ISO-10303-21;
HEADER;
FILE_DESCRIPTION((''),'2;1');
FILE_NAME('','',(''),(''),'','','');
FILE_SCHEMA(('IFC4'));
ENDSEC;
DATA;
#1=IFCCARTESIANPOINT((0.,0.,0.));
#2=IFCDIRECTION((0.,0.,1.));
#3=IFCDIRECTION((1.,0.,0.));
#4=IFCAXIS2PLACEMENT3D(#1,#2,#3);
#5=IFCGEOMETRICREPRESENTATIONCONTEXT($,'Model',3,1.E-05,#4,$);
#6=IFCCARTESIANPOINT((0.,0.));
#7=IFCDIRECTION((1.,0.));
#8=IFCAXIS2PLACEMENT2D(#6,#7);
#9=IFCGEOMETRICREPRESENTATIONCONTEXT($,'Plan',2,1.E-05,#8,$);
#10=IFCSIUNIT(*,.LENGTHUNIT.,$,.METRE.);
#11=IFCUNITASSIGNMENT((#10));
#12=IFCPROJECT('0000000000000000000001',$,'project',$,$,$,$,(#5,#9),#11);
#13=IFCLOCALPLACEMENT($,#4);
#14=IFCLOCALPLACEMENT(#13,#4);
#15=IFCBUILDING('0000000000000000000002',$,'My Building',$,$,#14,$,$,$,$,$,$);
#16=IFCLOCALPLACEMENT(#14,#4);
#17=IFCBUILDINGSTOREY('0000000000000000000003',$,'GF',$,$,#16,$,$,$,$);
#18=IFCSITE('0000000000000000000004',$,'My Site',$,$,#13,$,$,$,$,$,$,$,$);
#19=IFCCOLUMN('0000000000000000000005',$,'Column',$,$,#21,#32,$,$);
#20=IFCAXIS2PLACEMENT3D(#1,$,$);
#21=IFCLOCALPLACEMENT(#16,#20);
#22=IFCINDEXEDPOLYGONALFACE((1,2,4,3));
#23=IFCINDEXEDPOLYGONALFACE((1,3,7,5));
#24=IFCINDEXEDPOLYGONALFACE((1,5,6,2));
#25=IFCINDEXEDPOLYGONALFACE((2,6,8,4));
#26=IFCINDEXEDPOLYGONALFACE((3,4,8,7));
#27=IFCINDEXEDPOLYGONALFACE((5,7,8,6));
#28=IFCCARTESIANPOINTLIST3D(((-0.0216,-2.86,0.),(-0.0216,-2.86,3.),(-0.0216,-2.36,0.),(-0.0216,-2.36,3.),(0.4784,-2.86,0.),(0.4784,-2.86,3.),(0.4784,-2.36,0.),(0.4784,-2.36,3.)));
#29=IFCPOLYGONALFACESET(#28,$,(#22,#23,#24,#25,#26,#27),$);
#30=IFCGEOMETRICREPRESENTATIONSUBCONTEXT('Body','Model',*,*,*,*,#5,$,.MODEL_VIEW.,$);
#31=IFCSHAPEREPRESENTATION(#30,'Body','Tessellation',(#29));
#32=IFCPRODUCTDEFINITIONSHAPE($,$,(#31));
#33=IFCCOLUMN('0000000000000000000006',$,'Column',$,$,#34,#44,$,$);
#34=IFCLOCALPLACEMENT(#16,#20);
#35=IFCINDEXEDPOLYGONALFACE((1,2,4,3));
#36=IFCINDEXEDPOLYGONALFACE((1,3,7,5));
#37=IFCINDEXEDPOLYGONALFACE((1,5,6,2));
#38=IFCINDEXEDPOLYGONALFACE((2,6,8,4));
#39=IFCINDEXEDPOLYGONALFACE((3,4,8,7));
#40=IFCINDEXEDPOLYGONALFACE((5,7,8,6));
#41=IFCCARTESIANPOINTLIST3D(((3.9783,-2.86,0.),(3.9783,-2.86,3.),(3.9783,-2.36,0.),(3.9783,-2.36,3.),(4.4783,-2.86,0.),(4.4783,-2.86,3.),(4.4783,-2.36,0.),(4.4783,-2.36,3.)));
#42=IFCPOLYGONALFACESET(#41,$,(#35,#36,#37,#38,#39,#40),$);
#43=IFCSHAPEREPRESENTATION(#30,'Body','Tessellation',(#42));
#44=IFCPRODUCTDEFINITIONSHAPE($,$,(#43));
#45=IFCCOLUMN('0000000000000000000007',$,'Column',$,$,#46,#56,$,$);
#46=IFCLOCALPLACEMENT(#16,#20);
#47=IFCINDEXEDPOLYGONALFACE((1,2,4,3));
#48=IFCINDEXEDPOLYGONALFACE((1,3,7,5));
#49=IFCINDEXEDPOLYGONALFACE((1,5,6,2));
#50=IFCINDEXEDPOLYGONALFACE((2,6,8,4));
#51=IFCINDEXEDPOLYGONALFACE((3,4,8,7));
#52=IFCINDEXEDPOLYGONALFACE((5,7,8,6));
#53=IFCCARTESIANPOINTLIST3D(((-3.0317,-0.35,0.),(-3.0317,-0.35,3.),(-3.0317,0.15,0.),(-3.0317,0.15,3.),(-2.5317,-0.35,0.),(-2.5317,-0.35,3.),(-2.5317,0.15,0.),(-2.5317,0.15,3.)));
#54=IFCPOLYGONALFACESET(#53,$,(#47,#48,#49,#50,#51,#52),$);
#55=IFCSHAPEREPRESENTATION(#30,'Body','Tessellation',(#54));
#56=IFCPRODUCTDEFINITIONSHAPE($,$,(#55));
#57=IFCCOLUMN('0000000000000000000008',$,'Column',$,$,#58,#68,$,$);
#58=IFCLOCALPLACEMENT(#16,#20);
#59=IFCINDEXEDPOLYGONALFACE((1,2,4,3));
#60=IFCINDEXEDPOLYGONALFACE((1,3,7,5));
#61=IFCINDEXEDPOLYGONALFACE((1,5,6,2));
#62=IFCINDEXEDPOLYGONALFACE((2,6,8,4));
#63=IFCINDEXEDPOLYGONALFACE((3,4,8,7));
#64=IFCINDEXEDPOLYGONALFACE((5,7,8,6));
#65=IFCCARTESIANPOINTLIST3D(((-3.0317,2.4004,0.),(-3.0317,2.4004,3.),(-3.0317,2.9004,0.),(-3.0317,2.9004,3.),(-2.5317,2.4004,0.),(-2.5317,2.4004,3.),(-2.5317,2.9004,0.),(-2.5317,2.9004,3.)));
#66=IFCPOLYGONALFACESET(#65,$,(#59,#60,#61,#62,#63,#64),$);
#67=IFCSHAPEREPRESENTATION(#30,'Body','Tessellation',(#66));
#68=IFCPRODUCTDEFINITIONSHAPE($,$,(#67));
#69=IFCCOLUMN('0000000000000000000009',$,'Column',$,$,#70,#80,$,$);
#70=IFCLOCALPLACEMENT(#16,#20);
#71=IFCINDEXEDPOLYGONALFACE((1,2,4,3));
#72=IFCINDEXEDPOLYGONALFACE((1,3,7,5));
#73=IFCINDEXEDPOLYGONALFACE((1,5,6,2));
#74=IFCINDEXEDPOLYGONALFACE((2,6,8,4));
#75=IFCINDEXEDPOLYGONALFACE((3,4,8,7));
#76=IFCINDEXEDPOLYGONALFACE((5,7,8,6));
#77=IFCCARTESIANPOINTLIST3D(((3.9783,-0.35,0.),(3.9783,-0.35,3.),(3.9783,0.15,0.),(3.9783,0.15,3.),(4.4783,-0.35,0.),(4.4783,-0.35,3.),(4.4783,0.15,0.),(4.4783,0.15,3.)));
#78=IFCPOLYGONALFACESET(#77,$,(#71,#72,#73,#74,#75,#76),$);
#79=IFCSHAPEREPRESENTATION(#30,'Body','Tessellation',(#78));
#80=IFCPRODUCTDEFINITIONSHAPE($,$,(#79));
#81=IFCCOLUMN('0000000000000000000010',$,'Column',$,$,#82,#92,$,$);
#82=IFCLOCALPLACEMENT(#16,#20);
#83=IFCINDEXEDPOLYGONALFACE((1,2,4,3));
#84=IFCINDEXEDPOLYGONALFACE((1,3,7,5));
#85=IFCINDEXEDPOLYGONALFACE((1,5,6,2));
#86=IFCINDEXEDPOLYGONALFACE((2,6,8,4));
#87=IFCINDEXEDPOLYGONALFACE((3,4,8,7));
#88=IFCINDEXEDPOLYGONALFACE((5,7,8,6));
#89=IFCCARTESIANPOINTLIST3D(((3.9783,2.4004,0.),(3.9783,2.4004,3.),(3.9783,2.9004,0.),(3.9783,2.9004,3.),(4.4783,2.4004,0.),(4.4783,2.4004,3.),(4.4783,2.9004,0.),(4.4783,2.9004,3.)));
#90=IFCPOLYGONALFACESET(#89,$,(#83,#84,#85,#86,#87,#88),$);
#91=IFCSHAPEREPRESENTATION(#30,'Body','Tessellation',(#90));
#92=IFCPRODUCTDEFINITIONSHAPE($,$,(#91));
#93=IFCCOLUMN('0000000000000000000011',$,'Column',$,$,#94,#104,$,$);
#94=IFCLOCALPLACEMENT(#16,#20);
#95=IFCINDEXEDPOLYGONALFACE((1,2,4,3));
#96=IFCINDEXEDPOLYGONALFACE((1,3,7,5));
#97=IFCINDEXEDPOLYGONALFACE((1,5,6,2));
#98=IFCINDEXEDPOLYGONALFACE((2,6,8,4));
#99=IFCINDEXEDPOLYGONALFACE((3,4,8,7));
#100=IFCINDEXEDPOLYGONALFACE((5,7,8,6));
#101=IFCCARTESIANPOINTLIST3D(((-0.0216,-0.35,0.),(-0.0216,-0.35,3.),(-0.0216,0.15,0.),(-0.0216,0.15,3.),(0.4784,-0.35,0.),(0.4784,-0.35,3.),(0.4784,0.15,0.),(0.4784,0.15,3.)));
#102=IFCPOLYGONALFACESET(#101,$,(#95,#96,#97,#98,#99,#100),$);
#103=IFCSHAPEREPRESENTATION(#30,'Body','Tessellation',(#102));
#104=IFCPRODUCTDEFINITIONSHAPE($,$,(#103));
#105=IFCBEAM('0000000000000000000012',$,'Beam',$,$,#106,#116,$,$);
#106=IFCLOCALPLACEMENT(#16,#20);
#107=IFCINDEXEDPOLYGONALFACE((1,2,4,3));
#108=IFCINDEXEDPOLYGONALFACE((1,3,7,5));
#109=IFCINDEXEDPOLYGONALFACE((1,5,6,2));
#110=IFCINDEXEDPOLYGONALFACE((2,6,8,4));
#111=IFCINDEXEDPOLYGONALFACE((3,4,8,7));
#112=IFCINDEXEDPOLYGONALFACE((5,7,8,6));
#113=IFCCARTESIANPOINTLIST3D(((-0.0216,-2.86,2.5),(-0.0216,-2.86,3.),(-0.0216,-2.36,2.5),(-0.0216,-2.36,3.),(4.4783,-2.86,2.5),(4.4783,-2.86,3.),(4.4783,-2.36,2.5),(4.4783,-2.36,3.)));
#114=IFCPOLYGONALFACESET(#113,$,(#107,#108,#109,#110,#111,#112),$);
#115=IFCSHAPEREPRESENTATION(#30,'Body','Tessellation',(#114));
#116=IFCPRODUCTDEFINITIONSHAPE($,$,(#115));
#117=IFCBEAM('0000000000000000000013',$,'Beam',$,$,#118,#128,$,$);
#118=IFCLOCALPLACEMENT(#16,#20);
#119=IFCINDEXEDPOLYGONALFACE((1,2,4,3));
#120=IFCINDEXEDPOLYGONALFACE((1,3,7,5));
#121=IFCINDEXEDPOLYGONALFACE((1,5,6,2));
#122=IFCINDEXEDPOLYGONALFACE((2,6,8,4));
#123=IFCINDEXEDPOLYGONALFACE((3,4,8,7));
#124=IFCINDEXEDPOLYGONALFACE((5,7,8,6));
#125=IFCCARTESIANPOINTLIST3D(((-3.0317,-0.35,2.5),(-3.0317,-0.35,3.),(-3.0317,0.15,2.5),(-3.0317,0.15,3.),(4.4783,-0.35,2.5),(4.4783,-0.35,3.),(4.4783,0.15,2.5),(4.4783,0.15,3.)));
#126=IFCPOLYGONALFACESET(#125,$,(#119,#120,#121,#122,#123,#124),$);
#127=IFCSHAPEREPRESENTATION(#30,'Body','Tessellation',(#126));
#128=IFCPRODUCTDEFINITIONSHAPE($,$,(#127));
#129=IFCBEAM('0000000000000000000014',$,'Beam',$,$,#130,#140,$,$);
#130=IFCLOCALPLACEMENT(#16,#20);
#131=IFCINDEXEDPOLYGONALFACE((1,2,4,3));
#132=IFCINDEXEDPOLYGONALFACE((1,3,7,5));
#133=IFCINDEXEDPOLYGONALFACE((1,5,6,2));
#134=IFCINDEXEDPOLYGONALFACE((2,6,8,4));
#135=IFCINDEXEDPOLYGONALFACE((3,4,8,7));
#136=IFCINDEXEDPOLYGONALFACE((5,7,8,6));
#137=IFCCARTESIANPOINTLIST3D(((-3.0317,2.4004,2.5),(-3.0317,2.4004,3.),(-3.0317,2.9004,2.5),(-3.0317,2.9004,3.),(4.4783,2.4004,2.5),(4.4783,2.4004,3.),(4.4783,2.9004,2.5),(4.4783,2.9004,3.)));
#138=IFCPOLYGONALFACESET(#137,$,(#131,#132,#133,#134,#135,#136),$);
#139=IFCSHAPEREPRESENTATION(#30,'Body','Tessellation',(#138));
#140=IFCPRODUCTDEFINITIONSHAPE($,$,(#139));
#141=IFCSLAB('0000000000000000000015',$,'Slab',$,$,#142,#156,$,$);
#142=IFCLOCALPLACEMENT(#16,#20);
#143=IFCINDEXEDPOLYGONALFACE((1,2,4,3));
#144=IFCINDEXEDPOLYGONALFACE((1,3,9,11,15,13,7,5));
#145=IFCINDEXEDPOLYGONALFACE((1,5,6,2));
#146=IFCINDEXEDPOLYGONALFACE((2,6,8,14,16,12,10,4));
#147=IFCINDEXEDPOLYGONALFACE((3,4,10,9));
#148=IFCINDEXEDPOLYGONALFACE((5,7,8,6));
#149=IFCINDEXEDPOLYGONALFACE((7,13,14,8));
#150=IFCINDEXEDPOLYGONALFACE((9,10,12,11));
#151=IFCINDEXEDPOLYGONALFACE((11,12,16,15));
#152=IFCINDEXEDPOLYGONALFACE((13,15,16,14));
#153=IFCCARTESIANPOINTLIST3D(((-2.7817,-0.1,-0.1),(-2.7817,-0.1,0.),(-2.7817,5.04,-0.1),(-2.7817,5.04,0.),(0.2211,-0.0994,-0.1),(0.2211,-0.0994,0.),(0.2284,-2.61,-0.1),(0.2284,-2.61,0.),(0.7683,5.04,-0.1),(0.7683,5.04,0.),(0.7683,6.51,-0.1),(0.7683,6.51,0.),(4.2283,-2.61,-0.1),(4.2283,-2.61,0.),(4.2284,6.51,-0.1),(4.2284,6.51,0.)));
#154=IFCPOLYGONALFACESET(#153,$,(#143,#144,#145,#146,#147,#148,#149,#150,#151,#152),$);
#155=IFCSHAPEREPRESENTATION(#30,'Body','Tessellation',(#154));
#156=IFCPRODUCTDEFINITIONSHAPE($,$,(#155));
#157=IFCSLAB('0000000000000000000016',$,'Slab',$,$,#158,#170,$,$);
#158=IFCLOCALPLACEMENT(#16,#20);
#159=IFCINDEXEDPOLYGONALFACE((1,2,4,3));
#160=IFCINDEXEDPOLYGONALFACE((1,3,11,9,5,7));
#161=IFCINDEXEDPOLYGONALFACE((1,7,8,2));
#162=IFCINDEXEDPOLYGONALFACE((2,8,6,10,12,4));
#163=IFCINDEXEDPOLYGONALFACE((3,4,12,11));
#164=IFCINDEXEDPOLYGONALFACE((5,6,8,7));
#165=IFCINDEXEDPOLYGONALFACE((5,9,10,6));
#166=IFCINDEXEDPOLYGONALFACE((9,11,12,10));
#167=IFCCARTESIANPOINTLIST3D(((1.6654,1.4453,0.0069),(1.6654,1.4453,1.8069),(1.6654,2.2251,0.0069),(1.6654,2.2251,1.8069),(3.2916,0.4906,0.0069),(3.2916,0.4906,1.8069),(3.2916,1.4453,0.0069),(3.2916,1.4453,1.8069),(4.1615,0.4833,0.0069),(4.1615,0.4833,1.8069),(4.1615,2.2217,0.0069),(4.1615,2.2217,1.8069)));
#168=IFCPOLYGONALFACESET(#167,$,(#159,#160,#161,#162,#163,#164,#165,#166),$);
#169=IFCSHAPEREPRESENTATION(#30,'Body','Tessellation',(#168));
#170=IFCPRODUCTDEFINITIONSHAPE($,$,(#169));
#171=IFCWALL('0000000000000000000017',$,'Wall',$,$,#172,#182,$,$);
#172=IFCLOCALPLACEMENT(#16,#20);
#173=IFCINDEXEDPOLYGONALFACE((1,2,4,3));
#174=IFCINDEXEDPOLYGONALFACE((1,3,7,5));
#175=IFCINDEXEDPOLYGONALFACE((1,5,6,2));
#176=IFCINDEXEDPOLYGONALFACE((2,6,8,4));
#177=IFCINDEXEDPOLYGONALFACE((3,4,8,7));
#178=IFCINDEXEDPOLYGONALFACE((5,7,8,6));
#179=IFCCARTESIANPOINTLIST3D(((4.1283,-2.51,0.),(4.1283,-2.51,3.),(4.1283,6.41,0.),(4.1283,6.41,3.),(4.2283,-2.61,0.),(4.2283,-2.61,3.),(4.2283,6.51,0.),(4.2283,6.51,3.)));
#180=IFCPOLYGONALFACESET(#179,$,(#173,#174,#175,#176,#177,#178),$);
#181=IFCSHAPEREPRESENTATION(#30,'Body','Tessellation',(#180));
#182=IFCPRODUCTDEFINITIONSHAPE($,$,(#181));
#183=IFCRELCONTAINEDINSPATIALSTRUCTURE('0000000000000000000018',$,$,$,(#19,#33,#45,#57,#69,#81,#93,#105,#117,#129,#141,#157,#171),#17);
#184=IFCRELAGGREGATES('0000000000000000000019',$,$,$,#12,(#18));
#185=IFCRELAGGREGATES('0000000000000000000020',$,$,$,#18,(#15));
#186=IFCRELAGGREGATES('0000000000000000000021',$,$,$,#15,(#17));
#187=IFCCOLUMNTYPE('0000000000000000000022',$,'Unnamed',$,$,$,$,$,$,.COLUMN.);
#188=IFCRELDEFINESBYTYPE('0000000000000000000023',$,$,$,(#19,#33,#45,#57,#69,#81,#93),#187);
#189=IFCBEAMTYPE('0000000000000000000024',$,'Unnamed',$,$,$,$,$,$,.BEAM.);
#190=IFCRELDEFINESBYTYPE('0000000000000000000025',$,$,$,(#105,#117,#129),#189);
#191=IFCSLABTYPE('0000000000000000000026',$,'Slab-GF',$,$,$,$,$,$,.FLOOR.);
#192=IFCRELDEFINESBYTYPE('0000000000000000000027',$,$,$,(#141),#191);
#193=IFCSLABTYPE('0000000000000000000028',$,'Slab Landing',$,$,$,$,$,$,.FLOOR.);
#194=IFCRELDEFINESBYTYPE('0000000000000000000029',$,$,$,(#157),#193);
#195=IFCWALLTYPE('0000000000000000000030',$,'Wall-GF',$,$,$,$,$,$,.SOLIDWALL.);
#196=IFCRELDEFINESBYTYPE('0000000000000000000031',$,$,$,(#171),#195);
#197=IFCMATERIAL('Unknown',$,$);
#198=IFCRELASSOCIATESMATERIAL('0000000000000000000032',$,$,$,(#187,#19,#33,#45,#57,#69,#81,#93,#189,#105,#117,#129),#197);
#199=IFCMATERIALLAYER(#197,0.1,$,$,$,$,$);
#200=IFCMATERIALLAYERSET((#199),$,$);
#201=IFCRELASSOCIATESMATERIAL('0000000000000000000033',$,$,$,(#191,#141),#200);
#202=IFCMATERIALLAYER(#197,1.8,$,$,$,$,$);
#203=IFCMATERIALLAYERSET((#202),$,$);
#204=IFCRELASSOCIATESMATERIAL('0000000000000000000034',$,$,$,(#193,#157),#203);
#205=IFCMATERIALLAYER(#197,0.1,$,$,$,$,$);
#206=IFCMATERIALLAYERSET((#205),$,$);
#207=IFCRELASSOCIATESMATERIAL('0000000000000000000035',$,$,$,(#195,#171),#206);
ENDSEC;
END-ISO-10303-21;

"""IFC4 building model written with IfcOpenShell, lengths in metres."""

from ifc_helpers import new_model, si_unit, frame, origin_with_axes, origin_2d_with_axis, place, context, subcontext, project, spatial, line, indexed_curve, rectangle, outline, extrude, material, layer, layer_set, layer_usage, material_profile, profile_set, profile_usage, type_object, element, save


model = new_model("IFC4")

# Units and contexts
model_context = context("Model", 3, precision=1e-05, world=origin_with_axes())
plan_context = context("Plan", 2, precision=1e-05, world=origin_2d_with_axis())
body_context_1 = subcontext(model_context, "Body", "Model", "MODEL_VIEW")
ifc_project = project(units=[si_unit("LENGTHUNIT", "METRE")], contexts=[model_context, plan_context])

# Site, building, storey
site_placement = place(None, origin_with_axes())
site = spatial("IfcSite", under=ifc_project, at=site_placement, Name="My Site")
building_placement = place(site_placement, origin_with_axes())
building = spatial("IfcBuilding", under=site, at=building_placement, Name="My Building")
storey_placement = place(building_placement, origin_with_axes())
storey = spatial("IfcBuildingStorey", under=building, at=storey_placement, Name="GF")

# Columns
ifc_material = material(Name="Unknown")
ifc_material_profile_1 = material_profile(ifc_material, rectangle(XDim=0.5, YDim=0.5))
ifc_profile_set_1 = profile_set([ifc_material_profile_1])
ifc_profile_usage_1 = profile_usage(ifc_profile_set_1, cardinal=5)
column_type = type_object("IfcColumnType", Name="Unnamed", PredefinedType="COLUMN", material=ifc_profile_set_1)
column_1_placement = place(storey_placement, frame((0.2284, -2.61, 0.0), z_axis=(0.0, 0.0, 1.0), x_axis=(1.0, 0.0, 0.0)))
element("IfcColumn", 1, at=column_1_placement, inside=storey, type_object=column_type, material=ifc_profile_usage_1, Name="Column", context=body_context_1, shape_type="SweptSolid", body=[
    extrude(rectangle(XDim=0.5, YDim=0.5), origin_with_axes(), (0.0, 0.0, 1.0), 3.0),
])
ifc_profile_usage_2 = profile_usage(ifc_profile_set_1, cardinal=5)
column_2_placement = place(storey_placement, frame((4.2283, -2.61, 0.0), z_axis=(0.0, 0.0, 1.0), x_axis=(1.0, 0.0, 0.0)))
element("IfcColumn", 2, at=column_2_placement, inside=storey, type_object=column_type, material=ifc_profile_usage_2, Name="Column", context=body_context_1, shape_type="SweptSolid", body=[
    extrude(rectangle(XDim=0.5, YDim=0.5), origin_with_axes(), (0.0, 0.0, 1.0), 3.0),
])
ifc_profile_usage_3 = profile_usage(ifc_profile_set_1, cardinal=5)
column_3_placement = place(storey_placement, frame((-2.7817, -0.1, 0.0), z_axis=(0.0, 0.0, 1.0), x_axis=(1.0, 0.0, 0.0)))
element("IfcColumn", 3, at=column_3_placement, inside=storey, type_object=column_type, material=ifc_profile_usage_3, Name="Column", context=body_context_1, shape_type="SweptSolid", body=[
    extrude(rectangle(XDim=0.5, YDim=0.5), origin_with_axes(), (0.0, 0.0, 1.0), 3.0),
])
ifc_profile_usage_4 = profile_usage(ifc_profile_set_1, cardinal=5)
column_4_placement = place(storey_placement, frame((-2.7817, 2.6504, 0.0), z_axis=(0.0, 0.0, 1.0), x_axis=(1.0, 0.0, 0.0)))
element("IfcColumn", 4, at=column_4_placement, inside=storey, type_object=column_type, material=ifc_profile_usage_4, Name="Column", context=body_context_1, shape_type="SweptSolid", body=[
    extrude(rectangle(XDim=0.5, YDim=0.5), origin_with_axes(), (0.0, 0.0, 1.0), 3.0),
])
ifc_profile_usage_5 = profile_usage(ifc_profile_set_1, cardinal=5)
column_5_placement = place(storey_placement, frame((4.2283, -0.1, 0.0), z_axis=(0.0, 0.0, 1.0), x_axis=(1.0, 0.0, 0.0)))
element("IfcColumn", 5, at=column_5_placement, inside=storey, type_object=column_type, material=ifc_profile_usage_5, Name="Column", context=body_context_1, shape_type="SweptSolid", body=[
    extrude(rectangle(XDim=0.5, YDim=0.5), origin_with_axes(), (0.0, 0.0, 1.0), 3.0),
])
ifc_profile_usage_6 = profile_usage(ifc_profile_set_1, cardinal=5)
column_6_placement = place(storey_placement, frame((4.2283, 2.6504, 0.0), z_axis=(0.0, 0.0, 1.0), x_axis=(1.0, 0.0, 0.0)))
element("IfcColumn", 6, at=column_6_placement, inside=storey, type_object=column_type, material=ifc_profile_usage_6, Name="Column", context=body_context_1, shape_type="SweptSolid", body=[
    extrude(rectangle(XDim=0.5, YDim=0.5), origin_with_axes(), (0.0, 0.0, 1.0), 3.0),
])
ifc_profile_usage_7 = profile_usage(ifc_profile_set_1, cardinal=5)
column_7_placement = place(storey_placement, frame((0.2284, -0.1, 0.0), z_axis=(0.0, 0.0, 1.0), x_axis=(1.0, 0.0, 0.0)))
element("IfcColumn", 7, at=column_7_placement, inside=storey, type_object=column_type, material=ifc_profile_usage_7, Name="Column", context=body_context_1, shape_type="SweptSolid", body=[
    extrude(rectangle(XDim=0.5, YDim=0.5), origin_with_axes(), (0.0, 0.0, 1.0), 3.0),
])

# Beams
ifc_material_profile_2 = material_profile(ifc_material, rectangle(XDim=0.5, YDim=0.5))
ifc_profile_set_2 = profile_set([ifc_material_profile_2])
ifc_profile_usage_8 = profile_usage(ifc_profile_set_2, cardinal=3)
beam_type = type_object("IfcBeamType", Name="Unnamed", PredefinedType="BEAM", material=ifc_profile_set_2)
beam_1_placement = place(storey_placement, frame((-0.0216, -2.86, 2.5), z_axis=(1.0, 0.0, 0.0), x_axis=(0.0, 1.0, 0.0)))
element("IfcBeam", 8, at=beam_1_placement, inside=storey, type_object=beam_type, material=ifc_profile_usage_8, Name="Beam", context=body_context_1, shape_type="SweptSolid", body=[
    extrude(rectangle(XDim=0.5, YDim=0.5), frame((0.25, 0.25, 0.0), z_axis=(0.0, 0.0, 1.0), x_axis=(1.0, 0.0, 0.0)), (0.0, 0.0, 1.0), 4.5),
])
ifc_profile_usage_9 = profile_usage(ifc_profile_set_2, cardinal=7)
beam_2_placement = place(storey_placement, frame((4.4783, -0.35, 3.0), z_axis=(-1.0, 0.0, 0.0), x_axis=(0.0, -1.0, 0.0)))
element("IfcBeam", 9, at=beam_2_placement, inside=storey, type_object=beam_type, material=ifc_profile_usage_9, Name="Beam", context=body_context_1, shape_type="SweptSolid", body=[
    extrude(rectangle(XDim=0.5, YDim=0.5), frame((-0.25, -0.25, 0.0), z_axis=(0.0, 0.0, 1.0), x_axis=(1.0, 0.0, 0.0)), (0.0, 0.0, 1.0), 7.51),
])
ifc_profile_usage_10 = profile_usage(ifc_profile_set_2, cardinal=7)
beam_3_placement = place(storey_placement, frame((4.4783, 2.4004, 3.0), z_axis=(-1.0, 0.0, 0.0), x_axis=(0.0, -1.0, 0.0)))
element("IfcBeam", 10, at=beam_3_placement, inside=storey, type_object=beam_type, material=ifc_profile_usage_10, Name="Beam", context=body_context_1, shape_type="SweptSolid", body=[
    extrude(rectangle(XDim=0.5, YDim=0.5), frame((-0.25, -0.25, 0.0), z_axis=(0.0, 0.0, 1.0), x_axis=(1.0, 0.0, 0.0)), (0.0, 0.0, 1.0), 7.51),
])

# Slabs
ifc_layer_1 = layer(ifc_material, 0.1)
ifc_layer_set_1 = layer_set([ifc_layer_1])
ifc_layer_usage_1 = layer_usage(ifc_layer_set_1, "AXIS3", "POSITIVE", -0.1)
slab_type_1 = type_object("IfcSlabType", Name="Slab-GF", PredefinedType="FLOOR", material=ifc_layer_set_1)
slab_1_placement = place(storey_placement, frame((4.2283, -2.61, 0.0), z_axis=(0.0, 0.0, 1.0), x_axis=(1.0, 0.0, 0.0)))
element("IfcSlab", 11, at=slab_1_placement, inside=storey, type_object=slab_type_1, material=ifc_layer_usage_1, Name="Slab", context=body_context_1, shape_type="SweptSolid", body=[
    extrude(outline(indexed_curve([(0.0, 0.0), (0.0, 9.12), (-3.46, 9.12), (-3.46, 7.65), (-7.01, 7.65), (-7.01, 2.51), (-4.0073, 2.5106), (-4.0, 0.0), (0.0, 0.0)])), frame((0.0, 0.0, -0.1), z_axis=(0.0, 0.0, 1.0), x_axis=(1.0, 0.0, 0.0)), (0.0, 0.0, 1.0), 0.1),
])
ifc_layer_2 = layer(ifc_material, 1.8)
ifc_layer_set_2 = layer_set([ifc_layer_2])
ifc_layer_usage_2 = layer_usage(ifc_layer_set_2, "AXIS3", "POSITIVE", -1.8)
slab_type_2 = type_object("IfcSlabType", Name="Slab Landing", PredefinedType="FLOOR", material=ifc_layer_set_2)
slab_2_placement = place(storey_placement, frame((1.6654, 2.2251, 1.8069), z_axis=(0.0, 0.0, 1.0), x_axis=(1.0, 0.0, 0.0)))
element("IfcSlab", 12, at=slab_2_placement, inside=storey, type_object=slab_type_2, material=ifc_layer_usage_2, Name="Slab", context=body_context_1, shape_type="SweptSolid", body=[
    extrude(outline(indexed_curve([(2.4962, -0.0034), (2.4962, -1.7418), (1.6262, -1.7345), (1.6262, -0.7798), (0.0, -0.7798), (0.0, 0.0), (2.4962, -0.0034)])), frame((0.0, 0.0, -1.8), z_axis=(0.0, 0.0, 1.0), x_axis=(1.0, 0.0, 0.0)), (0.0, 0.0, 1.0), 1.8),
])

# Shared definitions
ifc_layer_3 = layer(ifc_material, 0.1)
ifc_layer_set_3 = layer_set([ifc_layer_3])
wall_type = type_object("IfcWallType", Name="Wall-GF", PredefinedType="SOLIDWALL", material=ifc_layer_set_3)

# Wall
ifc_layer_usage_3 = layer_usage(ifc_layer_set_3, "AXIS2", "POSITIVE", 0.0)
wall_1_placement = place(storey_placement, frame((4.2283, -2.61, 0.0), z_axis=(0.0, 0.0, 1.0), x_axis=(0.0, 1.0, 0.0)))
element("IfcWall", 13, at=wall_1_placement, inside=storey, type_object=wall_type, material=ifc_layer_usage_3, Name="Wall", context=body_context_1, shape_type="SweptSolid", body=[
    extrude(outline(indexed_curve([(0.0, 0.0), (0.1, 0.1), (9.02, 0.1), (9.12, 0.0)], segments=[line(1, 2, 3, 4, 1)])), origin_with_axes(), (0.0, 0.0, 1.0), 3.0),
])

save(model, "model.ifc")
